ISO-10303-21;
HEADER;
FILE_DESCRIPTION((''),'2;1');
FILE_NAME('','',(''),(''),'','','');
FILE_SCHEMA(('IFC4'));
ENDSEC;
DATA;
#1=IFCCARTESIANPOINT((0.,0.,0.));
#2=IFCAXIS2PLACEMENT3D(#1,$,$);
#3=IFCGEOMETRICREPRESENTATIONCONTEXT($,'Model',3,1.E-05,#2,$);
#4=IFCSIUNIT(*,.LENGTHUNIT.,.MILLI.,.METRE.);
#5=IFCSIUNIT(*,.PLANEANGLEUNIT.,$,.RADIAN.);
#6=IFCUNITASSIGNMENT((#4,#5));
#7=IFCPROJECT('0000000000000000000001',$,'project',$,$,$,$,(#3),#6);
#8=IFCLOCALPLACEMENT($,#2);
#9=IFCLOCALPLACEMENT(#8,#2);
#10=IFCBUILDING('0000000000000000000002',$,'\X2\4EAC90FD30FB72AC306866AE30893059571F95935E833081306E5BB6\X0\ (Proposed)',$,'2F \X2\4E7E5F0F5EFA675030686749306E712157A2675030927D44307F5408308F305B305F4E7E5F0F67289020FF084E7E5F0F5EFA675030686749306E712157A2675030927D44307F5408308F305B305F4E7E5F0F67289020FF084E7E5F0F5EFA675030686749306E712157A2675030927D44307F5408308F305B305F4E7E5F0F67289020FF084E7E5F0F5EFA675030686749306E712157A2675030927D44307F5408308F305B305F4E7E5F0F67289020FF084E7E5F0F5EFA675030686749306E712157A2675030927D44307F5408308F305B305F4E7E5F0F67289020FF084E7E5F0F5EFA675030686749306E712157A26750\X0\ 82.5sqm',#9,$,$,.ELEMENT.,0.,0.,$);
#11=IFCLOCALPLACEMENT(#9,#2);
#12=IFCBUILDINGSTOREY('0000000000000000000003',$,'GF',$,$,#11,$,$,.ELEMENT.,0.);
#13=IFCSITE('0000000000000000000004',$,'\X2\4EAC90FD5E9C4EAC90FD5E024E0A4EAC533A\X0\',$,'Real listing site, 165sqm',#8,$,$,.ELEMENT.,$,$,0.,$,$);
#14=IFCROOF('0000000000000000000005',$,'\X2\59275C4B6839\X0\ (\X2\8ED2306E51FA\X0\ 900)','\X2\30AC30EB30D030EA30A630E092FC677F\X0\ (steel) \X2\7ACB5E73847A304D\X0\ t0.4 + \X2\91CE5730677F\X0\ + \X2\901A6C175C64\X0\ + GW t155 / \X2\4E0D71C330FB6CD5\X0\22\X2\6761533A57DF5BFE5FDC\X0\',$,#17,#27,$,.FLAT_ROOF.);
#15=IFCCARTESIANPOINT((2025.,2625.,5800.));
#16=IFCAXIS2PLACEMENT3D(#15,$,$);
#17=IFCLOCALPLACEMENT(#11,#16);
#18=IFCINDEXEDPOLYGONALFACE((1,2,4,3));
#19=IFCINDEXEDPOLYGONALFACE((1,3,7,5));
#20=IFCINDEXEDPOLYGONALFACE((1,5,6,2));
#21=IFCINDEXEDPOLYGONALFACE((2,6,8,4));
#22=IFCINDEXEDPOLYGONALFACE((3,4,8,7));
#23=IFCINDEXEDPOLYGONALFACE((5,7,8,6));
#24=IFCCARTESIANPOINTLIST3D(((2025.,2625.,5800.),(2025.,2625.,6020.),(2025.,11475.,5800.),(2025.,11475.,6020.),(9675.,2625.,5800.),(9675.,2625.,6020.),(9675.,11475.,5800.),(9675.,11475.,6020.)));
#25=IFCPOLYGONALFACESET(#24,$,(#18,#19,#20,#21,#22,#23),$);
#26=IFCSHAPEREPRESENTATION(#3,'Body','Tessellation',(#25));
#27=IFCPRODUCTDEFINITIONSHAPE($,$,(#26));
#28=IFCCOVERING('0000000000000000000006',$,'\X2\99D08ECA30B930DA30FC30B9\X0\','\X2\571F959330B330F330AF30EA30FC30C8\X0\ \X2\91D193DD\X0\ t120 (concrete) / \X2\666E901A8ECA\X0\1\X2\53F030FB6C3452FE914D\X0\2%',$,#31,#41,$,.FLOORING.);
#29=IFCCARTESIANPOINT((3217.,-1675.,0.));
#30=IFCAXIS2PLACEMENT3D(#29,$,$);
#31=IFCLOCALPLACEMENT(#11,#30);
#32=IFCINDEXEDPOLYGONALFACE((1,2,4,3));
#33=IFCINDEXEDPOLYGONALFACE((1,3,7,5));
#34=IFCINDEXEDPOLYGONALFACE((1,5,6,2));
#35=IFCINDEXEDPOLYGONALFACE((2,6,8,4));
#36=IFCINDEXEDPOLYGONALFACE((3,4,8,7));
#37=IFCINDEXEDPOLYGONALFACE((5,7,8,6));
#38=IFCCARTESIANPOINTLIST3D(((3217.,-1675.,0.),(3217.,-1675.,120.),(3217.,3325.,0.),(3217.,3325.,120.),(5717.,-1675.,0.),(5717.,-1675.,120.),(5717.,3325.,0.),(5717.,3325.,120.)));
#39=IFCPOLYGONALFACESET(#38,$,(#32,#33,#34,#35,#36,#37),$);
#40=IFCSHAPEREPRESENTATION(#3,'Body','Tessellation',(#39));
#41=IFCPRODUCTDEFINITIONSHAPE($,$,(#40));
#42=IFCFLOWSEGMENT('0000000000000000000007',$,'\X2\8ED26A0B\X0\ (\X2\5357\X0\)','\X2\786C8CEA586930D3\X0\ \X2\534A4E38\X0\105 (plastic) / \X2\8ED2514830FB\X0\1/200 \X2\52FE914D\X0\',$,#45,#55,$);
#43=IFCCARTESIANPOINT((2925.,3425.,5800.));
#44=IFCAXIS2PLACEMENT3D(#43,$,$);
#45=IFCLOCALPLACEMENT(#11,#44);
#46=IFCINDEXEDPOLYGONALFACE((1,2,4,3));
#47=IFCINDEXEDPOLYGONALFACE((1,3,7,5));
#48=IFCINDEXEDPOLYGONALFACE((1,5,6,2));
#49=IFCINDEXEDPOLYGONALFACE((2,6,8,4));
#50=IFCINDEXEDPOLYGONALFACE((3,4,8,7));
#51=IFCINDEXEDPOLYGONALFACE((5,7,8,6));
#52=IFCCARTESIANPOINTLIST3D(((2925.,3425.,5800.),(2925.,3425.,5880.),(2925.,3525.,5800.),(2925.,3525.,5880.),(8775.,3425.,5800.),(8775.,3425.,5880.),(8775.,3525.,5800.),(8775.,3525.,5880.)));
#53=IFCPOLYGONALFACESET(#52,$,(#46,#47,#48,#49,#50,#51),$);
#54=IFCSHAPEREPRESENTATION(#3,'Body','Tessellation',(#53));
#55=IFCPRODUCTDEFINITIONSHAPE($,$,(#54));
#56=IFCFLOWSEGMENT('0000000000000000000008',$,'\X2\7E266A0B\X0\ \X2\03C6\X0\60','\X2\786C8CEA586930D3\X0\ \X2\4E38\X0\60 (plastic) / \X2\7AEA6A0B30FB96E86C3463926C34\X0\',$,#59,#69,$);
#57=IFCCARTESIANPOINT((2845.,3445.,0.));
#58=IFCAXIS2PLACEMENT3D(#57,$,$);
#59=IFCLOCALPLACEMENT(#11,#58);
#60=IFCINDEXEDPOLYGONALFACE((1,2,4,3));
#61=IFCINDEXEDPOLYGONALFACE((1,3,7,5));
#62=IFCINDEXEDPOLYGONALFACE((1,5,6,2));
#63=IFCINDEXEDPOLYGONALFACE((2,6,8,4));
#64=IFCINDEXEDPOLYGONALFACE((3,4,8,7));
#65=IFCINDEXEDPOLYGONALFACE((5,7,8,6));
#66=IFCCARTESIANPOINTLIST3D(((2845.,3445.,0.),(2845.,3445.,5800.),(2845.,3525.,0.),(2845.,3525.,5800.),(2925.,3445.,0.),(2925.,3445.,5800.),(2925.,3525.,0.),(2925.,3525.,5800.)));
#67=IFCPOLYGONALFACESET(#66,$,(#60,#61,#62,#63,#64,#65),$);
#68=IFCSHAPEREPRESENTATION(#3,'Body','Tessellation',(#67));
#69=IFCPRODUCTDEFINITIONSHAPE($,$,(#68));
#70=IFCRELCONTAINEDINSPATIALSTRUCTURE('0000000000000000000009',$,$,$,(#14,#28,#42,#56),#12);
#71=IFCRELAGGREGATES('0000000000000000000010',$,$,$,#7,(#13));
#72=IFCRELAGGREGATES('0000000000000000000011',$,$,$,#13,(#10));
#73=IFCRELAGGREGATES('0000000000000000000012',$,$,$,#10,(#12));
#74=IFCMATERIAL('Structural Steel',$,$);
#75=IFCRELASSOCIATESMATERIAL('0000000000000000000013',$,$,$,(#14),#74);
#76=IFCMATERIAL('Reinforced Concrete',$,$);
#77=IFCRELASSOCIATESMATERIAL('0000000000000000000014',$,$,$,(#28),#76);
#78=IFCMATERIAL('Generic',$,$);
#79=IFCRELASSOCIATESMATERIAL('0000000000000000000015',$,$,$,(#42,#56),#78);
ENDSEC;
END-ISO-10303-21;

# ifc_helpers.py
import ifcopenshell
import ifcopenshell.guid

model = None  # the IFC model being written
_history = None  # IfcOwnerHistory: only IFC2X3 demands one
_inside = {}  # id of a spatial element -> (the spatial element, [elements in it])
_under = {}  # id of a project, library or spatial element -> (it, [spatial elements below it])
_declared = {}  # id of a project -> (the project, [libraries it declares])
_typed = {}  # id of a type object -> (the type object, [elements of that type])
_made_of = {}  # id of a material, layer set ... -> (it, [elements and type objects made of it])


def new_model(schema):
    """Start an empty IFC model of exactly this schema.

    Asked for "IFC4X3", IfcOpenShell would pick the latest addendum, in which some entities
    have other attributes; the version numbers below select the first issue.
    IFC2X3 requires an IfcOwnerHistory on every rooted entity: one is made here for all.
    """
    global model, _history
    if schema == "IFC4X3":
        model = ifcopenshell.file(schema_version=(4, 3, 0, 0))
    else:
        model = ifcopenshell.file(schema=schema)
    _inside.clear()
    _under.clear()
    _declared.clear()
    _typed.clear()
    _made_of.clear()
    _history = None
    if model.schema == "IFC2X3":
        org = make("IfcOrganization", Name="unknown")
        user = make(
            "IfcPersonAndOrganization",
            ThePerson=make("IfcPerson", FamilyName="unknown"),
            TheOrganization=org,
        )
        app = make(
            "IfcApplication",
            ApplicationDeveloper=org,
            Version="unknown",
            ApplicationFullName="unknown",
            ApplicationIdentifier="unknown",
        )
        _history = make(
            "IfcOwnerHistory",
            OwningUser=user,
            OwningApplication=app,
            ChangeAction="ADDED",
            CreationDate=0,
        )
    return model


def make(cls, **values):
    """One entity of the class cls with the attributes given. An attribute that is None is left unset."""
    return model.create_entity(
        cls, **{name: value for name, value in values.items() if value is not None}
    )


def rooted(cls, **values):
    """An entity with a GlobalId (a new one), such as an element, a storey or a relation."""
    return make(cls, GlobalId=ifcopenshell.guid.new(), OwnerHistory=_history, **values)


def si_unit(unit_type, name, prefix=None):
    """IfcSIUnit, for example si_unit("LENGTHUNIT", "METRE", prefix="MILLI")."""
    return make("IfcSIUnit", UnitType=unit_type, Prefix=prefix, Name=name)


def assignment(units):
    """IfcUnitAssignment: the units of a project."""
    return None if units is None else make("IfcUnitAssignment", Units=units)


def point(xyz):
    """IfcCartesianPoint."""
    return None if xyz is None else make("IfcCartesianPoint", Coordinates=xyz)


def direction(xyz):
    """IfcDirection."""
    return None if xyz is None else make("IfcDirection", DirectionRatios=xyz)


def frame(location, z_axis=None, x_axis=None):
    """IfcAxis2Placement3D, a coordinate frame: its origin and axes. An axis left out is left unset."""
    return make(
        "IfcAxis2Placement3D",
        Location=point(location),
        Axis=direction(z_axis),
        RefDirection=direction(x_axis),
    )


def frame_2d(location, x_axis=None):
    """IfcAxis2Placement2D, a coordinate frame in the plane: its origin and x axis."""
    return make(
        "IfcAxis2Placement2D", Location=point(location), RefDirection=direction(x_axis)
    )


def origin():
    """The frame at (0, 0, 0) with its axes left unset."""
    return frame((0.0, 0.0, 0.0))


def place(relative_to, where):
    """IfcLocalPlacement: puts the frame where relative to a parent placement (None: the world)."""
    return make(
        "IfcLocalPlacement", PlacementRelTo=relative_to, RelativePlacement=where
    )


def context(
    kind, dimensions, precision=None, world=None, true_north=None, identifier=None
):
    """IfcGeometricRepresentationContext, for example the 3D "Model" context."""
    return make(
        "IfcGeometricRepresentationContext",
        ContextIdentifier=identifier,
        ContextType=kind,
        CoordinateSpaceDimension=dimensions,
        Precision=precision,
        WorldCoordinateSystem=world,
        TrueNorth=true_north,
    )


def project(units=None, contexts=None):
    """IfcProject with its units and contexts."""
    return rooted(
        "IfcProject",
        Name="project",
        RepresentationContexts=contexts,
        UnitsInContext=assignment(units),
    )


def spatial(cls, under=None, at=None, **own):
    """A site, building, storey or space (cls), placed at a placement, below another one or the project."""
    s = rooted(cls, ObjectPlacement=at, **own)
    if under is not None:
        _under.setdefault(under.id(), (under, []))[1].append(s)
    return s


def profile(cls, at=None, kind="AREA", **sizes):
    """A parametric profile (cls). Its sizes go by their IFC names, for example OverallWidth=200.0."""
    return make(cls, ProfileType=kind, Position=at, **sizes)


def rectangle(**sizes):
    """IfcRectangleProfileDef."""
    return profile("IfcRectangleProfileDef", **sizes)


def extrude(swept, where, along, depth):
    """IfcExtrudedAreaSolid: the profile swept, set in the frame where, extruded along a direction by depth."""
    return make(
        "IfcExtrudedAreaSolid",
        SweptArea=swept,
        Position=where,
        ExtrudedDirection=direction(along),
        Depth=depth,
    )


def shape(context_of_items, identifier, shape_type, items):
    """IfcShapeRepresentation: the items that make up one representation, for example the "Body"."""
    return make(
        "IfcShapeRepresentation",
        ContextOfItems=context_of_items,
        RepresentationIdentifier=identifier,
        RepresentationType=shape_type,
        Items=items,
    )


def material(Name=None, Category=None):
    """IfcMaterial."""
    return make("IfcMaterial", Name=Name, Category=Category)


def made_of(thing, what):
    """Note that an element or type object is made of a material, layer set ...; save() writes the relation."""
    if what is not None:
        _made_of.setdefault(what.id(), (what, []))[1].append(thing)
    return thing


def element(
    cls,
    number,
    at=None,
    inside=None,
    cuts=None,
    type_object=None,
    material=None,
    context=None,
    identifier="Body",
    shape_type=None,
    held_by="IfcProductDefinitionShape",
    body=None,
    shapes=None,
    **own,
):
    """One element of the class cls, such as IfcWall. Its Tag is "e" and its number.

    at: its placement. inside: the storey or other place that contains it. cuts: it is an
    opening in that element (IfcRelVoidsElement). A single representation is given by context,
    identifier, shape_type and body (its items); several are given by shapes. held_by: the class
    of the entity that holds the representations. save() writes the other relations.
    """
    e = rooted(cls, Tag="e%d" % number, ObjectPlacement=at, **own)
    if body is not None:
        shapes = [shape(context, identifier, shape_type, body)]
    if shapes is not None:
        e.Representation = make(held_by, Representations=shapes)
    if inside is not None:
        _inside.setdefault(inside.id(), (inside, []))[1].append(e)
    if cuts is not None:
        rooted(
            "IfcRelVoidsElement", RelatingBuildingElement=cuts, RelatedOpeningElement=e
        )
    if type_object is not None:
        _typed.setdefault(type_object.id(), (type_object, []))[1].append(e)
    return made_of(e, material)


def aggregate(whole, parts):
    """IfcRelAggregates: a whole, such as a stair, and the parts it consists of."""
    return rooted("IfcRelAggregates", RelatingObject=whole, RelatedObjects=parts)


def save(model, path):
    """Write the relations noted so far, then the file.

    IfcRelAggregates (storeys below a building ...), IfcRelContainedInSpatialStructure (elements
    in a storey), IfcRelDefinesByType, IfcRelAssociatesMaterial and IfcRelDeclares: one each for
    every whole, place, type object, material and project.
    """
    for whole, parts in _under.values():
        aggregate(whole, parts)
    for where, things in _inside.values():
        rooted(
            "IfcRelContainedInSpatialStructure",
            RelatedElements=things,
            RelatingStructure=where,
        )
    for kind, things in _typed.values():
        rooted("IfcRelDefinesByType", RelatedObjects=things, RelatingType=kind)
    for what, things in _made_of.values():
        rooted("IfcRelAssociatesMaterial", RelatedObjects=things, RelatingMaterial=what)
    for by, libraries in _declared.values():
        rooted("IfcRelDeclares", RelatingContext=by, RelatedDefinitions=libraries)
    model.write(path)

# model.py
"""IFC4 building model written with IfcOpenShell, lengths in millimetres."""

from ifc_helpers import new_model, si_unit, frame, frame_2d, origin, place, context, project, spatial, rectangle, extrude, material, element, save


model = new_model("IFC4")

# Units and contexts
model_context = context("Model", 3, precision=1e-05, world=origin())
ifc_project = project(units=[si_unit("LENGTHUNIT", "METRE", prefix="MILLI"), si_unit("PLANEANGLEUNIT", "RADIAN")], contexts=[model_context])

# Site, building, storey
site_placement = place(None, origin())
site = spatial("IfcSite", under=ifc_project, at=site_placement, Name="京都府京都市上京区", ObjectType="Real listing site, 165sqm", CompositionType="ELEMENT", RefElevation=0.0)
building_placement = place(site_placement, origin())
building = spatial("IfcBuilding", under=site, at=building_placement, Name="京都・犬と暮らす土間広めの家 (Proposed)", ObjectType="2F 乾式建材と杉の無垢材を組み合わせた乾式木造（乾式建材と杉の無垢材を組み合わせた乾式木造（乾式建材と杉の無垢材を組み合わせた乾式木造（乾式建材と杉の無垢材を組み合わせた乾式木造（乾式建材と杉の無垢材を組み合わせた乾式木造（乾式建材と杉の無垢材 82.5sqm", CompositionType="ELEMENT", ElevationOfRefHeight=0.0, ElevationOfTerrain=0.0)
storey_placement = place(building_placement, origin())
storey = spatial("IfcBuildingStorey", under=building, at=storey_placement, Name="GF", CompositionType="ELEMENT", Elevation=0.0)

# Shared definitions
ifc_material_1 = material(Name="Reinforced Concrete")

# Roof
ifc_material_2 = material(Name="Structural Steel")
roof_placement = place(storey_placement, frame((2025.0, 2625.0, 5800.0)))
element("IfcRoof", 1, at=roof_placement, inside=storey, material=ifc_material_2, Name="大屋根 (軒の出 900)", Description="ガルバリウム鋼板 (steel) 立平葺き t0.4 + 野地板 + 通気層 + GW t155 / 不燃・法22条区域対応", PredefinedType="FLAT_ROOF", context=model_context, shape_type="SweptSolid", body=[
    extrude(rectangle(XDim=7650.0, YDim=8850.0, at=frame_2d((3825.0, 4425.0))), frame((2025.0, 2625.0, 5800.0)), (0.0, 0.0, 1.0), 220.0),
])

# Covering
covering_placement = place(storey_placement, frame((3217.0, -1675.0, 0.0)))
element("IfcCovering", 2, at=covering_placement, inside=storey, material=ifc_material_1, Name="駐車スペース", Description="土間コンクリート 金鏝 t120 (concrete) / 普通車1台・水勾配2%", PredefinedType="FLOORING", context=model_context, shape_type="SweptSolid", body=[
    extrude(rectangle(XDim=2500.0, YDim=5000.0, at=frame_2d((1250.0, 2500.0))), frame((3217.0, -1675.0, 0.0)), (0.0, 0.0, 1.0), 120.0),
])

# Flow segments
ifc_material_3 = material(Name="Generic")
flow_segment_1_placement = place(storey_placement, frame((2925.0, 3425.0, 5800.0)))
element("IfcFlowSegment", 3, at=flow_segment_1_placement, inside=storey, material=ifc_material_3, Name="軒樋 (南)", Description="硬質塩ビ 半丸105 (plastic) / 軒先・1/200 勾配", context=model_context, shape_type="SweptSolid", body=[
    extrude(rectangle(XDim=5850.0, YDim=100.0, at=frame_2d((2925.0, 50.0))), frame((2925.0, 3425.0, 5800.0)), (0.0, 0.0, 1.0), 80.0),
])
flow_segment_2_placement = place(storey_placement, frame((2845.0, 3445.0, 0.0)))
element("IfcFlowSegment", 4, at=flow_segment_2_placement, inside=storey, material=ifc_material_3, Name="縦樋 φ60", Description="硬質塩ビ 丸60 (plastic) / 竪樋・雨水排水", context=model_context, shape_type="SweptSolid", body=[
    extrude(rectangle(XDim=80.0, YDim=80.0, at=frame_2d((40.0, 40.0))), frame((2845.0, 3445.0, 0.0)), (0.0, 0.0, 1.0), 5800.0),
])

save(model, "model.ifc")
